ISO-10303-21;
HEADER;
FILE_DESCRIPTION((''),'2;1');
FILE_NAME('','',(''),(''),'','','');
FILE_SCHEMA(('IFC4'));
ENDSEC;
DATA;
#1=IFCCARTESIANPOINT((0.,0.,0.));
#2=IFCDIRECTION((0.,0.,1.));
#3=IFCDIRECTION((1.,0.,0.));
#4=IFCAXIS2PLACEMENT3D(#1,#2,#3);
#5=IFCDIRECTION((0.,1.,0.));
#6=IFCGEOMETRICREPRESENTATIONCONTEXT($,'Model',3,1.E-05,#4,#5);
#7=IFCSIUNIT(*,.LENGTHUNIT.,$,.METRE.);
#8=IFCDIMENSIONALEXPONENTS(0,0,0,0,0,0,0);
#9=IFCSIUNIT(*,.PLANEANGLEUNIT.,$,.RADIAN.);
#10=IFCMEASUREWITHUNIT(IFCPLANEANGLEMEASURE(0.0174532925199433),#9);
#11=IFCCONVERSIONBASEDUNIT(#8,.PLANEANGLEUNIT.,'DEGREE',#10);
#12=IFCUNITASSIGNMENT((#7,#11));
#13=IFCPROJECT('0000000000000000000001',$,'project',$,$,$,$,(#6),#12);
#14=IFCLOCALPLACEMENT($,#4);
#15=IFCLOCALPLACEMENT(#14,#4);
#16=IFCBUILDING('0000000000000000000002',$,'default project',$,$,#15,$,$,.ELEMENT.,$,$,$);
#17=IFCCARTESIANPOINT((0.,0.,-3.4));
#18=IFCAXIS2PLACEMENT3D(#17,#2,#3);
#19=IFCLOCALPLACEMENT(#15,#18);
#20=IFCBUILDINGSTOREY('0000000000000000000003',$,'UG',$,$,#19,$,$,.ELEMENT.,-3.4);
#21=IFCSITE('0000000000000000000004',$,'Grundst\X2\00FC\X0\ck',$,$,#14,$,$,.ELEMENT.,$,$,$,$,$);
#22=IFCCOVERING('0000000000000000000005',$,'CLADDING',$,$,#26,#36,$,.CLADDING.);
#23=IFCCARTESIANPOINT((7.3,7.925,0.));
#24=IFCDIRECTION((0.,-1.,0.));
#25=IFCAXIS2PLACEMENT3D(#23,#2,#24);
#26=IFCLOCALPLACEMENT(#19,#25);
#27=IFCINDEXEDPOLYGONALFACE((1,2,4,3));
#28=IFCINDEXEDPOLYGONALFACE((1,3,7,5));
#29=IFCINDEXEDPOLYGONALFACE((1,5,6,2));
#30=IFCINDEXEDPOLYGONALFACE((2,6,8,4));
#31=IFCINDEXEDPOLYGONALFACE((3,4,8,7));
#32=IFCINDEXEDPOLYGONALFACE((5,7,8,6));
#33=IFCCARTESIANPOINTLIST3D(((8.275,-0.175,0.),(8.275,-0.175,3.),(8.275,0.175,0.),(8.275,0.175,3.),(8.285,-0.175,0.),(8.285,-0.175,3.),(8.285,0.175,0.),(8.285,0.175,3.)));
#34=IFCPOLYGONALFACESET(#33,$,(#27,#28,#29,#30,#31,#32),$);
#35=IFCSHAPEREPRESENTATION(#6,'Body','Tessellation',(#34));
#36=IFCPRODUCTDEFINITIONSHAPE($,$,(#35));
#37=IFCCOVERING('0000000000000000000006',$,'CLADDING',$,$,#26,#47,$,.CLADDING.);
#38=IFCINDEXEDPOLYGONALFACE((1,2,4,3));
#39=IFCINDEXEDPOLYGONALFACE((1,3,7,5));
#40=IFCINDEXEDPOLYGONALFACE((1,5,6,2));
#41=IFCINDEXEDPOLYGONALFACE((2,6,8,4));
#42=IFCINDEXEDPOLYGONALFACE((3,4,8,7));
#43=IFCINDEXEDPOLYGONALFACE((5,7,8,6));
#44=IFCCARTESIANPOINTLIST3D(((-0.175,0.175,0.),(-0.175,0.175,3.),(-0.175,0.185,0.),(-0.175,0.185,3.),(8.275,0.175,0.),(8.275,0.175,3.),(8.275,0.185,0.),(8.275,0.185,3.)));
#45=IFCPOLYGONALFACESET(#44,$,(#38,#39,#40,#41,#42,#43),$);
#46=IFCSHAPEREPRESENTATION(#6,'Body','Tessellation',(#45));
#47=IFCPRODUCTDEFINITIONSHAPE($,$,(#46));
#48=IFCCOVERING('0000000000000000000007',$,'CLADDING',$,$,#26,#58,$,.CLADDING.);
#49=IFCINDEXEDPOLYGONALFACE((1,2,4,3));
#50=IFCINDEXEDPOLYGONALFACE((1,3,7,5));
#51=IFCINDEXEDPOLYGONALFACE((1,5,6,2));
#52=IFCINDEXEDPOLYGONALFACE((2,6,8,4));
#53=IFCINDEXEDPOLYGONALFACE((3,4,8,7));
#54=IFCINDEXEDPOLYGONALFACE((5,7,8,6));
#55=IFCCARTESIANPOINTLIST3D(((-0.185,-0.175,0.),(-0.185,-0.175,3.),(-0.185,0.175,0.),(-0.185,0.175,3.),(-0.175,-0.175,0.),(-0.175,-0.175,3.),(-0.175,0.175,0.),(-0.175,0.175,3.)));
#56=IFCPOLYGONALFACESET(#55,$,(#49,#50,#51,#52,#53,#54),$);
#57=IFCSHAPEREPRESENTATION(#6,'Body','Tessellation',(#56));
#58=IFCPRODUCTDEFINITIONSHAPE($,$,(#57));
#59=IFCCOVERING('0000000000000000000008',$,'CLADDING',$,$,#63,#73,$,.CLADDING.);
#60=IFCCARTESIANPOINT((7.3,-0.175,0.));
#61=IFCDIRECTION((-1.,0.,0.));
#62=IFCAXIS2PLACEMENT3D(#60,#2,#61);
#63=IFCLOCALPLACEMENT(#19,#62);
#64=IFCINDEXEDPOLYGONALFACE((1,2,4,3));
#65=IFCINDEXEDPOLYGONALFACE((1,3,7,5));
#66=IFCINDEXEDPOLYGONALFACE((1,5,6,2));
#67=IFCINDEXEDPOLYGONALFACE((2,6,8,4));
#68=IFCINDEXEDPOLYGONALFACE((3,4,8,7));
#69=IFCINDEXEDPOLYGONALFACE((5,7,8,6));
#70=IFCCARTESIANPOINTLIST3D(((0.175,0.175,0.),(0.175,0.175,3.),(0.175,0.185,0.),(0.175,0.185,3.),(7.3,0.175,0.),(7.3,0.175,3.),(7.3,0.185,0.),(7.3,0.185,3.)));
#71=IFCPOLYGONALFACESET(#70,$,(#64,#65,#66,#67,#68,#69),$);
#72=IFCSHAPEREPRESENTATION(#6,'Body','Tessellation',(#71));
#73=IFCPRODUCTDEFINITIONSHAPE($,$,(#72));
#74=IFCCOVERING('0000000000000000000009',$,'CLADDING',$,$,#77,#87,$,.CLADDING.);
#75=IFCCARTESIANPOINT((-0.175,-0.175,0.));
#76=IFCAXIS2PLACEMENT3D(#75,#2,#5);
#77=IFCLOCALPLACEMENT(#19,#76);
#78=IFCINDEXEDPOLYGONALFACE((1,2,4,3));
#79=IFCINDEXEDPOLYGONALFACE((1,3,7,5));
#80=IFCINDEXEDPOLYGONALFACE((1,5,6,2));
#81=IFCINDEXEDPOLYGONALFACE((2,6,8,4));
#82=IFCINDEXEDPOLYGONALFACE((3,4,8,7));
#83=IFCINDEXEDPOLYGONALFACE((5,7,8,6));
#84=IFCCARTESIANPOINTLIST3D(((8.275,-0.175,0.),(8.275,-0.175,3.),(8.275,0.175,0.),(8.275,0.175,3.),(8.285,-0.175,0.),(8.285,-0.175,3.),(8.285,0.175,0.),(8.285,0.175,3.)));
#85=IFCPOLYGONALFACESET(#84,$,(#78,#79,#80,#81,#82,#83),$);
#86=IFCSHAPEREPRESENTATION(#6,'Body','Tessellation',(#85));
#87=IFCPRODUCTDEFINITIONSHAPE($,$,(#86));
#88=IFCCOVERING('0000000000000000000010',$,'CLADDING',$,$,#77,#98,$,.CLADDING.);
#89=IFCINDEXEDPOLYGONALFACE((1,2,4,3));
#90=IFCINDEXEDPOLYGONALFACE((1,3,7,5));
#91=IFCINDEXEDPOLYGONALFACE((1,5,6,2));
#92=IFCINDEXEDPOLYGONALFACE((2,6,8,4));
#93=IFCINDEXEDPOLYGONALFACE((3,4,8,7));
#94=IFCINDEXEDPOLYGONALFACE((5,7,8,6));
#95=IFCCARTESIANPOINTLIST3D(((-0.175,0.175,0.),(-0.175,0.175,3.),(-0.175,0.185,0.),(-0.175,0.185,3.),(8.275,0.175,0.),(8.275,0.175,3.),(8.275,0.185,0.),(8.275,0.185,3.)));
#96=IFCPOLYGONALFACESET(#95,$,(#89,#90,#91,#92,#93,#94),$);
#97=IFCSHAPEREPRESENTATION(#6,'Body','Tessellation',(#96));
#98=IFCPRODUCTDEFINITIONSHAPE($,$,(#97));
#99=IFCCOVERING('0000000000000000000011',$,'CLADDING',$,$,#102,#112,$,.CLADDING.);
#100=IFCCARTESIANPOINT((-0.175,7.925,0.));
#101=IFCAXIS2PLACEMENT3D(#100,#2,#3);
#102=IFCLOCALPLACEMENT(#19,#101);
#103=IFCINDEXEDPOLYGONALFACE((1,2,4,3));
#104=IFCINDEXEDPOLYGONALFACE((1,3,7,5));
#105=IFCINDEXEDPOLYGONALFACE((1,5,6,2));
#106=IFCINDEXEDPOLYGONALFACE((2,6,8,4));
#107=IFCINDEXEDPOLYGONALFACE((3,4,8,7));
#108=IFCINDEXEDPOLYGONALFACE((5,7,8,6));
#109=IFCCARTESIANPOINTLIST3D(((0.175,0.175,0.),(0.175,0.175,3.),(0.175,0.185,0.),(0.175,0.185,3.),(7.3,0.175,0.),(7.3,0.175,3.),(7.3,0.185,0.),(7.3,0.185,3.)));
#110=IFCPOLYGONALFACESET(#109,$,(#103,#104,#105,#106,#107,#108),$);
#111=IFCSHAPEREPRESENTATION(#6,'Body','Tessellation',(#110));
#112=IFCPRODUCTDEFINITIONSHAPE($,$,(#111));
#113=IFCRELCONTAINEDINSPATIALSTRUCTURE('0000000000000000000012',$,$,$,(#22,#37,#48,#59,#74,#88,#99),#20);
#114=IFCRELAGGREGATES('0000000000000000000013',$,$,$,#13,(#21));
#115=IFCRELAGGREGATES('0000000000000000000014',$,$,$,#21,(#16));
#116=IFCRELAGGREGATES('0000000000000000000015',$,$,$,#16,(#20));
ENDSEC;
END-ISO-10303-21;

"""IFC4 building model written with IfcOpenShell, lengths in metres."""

from ifc_helpers import new_model, entity, si_unit, converted_unit, direction, frame, origin_with_axes, place, context, project, spatial, polyline, outline, extrude, element, save


model = new_model("IFC4")

# Units and contexts
model_context = context("Model", 3, precision=1e-05, world=origin_with_axes(), true_north=direction((0.0, 1.0, 0.0)))
ifc_project = project(units=[si_unit("LENGTHUNIT", "METRE"), converted_unit("PLANEANGLEUNIT", "DEGREE", entity("IfcPlaneAngleMeasure", 0.0174532925199433), si_unit("PLANEANGLEUNIT", "RADIAN"), dimensions=[0, 0, 0, 0, 0, 0, 0])], contexts=[model_context])

# Site, building, storey
site_placement = place(None, origin_with_axes())
site = spatial("IfcSite", under=ifc_project, at=site_placement, Name="Grundstück", CompositionType="ELEMENT")
building_placement = place(site_placement, origin_with_axes())
building = spatial("IfcBuilding", under=site, at=building_placement, Name="default project", CompositionType="ELEMENT")
placement_1 = place(building_placement, frame((0.0, 0.0, -3.4), z_axis=(0.0, 0.0, 1.0), x_axis=(1.0, 0.0, 0.0)))
storey = spatial("IfcBuildingStorey", under=building, at=placement_1, Name="UG", CompositionType="ELEMENT", Elevation=-3.4)

# Shared definitions
placement_2 = place(placement_1, frame((7.3, 7.925, 0.0), z_axis=(0.0, 0.0, 1.0), x_axis=(0.0, -1.0, 0.0)))
placement_3 = place(placement_1, frame((7.3, -0.175, 0.0), z_axis=(0.0, 0.0, 1.0), x_axis=(-1.0, 0.0, 0.0)))
placement_4 = place(placement_1, frame((-0.175, -0.175, 0.0), z_axis=(0.0, 0.0, 1.0), x_axis=(0.0, 1.0, 0.0)))
placement_5 = place(placement_1, frame((-0.175, 7.925, 0.0), z_axis=(0.0, 0.0, 1.0), x_axis=(1.0, 0.0, 0.0)))

# Coverings
element("IfcCovering", 1, at=placement_2, inside=storey, Name="CLADDING", PredefinedType="CLADDING", context=model_context, shape_type="SweptSolid", body=[
    extrude(outline(polyline([(8.285, -0.175), (8.285, 0.175), (8.275, 0.175), (8.275, -0.175), (8.285, -0.175)])), origin_with_axes(), (0.0, 0.0, 1.0), 3.0),
])
element("IfcCovering", 2, at=placement_2, inside=storey, Name="CLADDING", PredefinedType="CLADDING", context=model_context, shape_type="SweptSolid", body=[
    extrude(outline(polyline([(8.275, 0.185), (-0.175, 0.185), (-0.175, 0.175), (8.275, 0.175), (8.275, 0.185)])), origin_with_axes(), (0.0, 0.0, 1.0), 3.0),
])
element("IfcCovering", 3, at=placement_2, inside=storey, Name="CLADDING", PredefinedType="CLADDING", context=model_context, shape_type="SweptSolid", body=[
    extrude(outline(polyline([(-0.185, 0.175), (-0.185, -0.175), (-0.175, -0.175), (-0.175, 0.175), (-0.185, 0.175)])), origin_with_axes(), (0.0, 0.0, 1.0), 3.0),
])
element("IfcCovering", 4, at=placement_3, inside=storey, Name="CLADDING", PredefinedType="CLADDING", context=model_context, shape_type="SweptSolid", body=[
    extrude(outline(polyline([(7.3, 0.185), (0.175, 0.185), (0.175, 0.175), (7.3, 0.175), (7.3, 0.185)])), origin_with_axes(), (0.0, 0.0, 1.0), 3.0),
])
element("IfcCovering", 5, at=placement_4, inside=storey, Name="CLADDING", PredefinedType="CLADDING", context=model_context, shape_type="SweptSolid", body=[
    extrude(outline(polyline([(8.285, -0.175), (8.285, 0.175), (8.275, 0.175), (8.275, -0.175), (8.285, -0.175)])), origin_with_axes(), (0.0, 0.0, 1.0), 3.0),
])
element("IfcCovering", 6, at=placement_4, inside=storey, Name="CLADDING", PredefinedType="CLADDING", context=model_context, shape_type="SweptSolid", body=[
    extrude(outline(polyline([(8.275, 0.185), (-0.175, 0.185), (-0.175, 0.175), (8.275, 0.175), (8.275, 0.185)])), origin_with_axes(), (0.0, 0.0, 1.0), 3.0),
])
element("IfcCovering", 7, at=placement_5, inside=storey, Name="CLADDING", PredefinedType="CLADDING", context=model_context, shape_type="SweptSolid", body=[
    extrude(outline(polyline([(7.3, 0.185), (0.175, 0.185), (0.175, 0.175), (7.3, 0.175), (7.3, 0.185)])), origin_with_axes(), (0.0, 0.0, 1.0), 3.0),
])

save(model, "model.ifc")
